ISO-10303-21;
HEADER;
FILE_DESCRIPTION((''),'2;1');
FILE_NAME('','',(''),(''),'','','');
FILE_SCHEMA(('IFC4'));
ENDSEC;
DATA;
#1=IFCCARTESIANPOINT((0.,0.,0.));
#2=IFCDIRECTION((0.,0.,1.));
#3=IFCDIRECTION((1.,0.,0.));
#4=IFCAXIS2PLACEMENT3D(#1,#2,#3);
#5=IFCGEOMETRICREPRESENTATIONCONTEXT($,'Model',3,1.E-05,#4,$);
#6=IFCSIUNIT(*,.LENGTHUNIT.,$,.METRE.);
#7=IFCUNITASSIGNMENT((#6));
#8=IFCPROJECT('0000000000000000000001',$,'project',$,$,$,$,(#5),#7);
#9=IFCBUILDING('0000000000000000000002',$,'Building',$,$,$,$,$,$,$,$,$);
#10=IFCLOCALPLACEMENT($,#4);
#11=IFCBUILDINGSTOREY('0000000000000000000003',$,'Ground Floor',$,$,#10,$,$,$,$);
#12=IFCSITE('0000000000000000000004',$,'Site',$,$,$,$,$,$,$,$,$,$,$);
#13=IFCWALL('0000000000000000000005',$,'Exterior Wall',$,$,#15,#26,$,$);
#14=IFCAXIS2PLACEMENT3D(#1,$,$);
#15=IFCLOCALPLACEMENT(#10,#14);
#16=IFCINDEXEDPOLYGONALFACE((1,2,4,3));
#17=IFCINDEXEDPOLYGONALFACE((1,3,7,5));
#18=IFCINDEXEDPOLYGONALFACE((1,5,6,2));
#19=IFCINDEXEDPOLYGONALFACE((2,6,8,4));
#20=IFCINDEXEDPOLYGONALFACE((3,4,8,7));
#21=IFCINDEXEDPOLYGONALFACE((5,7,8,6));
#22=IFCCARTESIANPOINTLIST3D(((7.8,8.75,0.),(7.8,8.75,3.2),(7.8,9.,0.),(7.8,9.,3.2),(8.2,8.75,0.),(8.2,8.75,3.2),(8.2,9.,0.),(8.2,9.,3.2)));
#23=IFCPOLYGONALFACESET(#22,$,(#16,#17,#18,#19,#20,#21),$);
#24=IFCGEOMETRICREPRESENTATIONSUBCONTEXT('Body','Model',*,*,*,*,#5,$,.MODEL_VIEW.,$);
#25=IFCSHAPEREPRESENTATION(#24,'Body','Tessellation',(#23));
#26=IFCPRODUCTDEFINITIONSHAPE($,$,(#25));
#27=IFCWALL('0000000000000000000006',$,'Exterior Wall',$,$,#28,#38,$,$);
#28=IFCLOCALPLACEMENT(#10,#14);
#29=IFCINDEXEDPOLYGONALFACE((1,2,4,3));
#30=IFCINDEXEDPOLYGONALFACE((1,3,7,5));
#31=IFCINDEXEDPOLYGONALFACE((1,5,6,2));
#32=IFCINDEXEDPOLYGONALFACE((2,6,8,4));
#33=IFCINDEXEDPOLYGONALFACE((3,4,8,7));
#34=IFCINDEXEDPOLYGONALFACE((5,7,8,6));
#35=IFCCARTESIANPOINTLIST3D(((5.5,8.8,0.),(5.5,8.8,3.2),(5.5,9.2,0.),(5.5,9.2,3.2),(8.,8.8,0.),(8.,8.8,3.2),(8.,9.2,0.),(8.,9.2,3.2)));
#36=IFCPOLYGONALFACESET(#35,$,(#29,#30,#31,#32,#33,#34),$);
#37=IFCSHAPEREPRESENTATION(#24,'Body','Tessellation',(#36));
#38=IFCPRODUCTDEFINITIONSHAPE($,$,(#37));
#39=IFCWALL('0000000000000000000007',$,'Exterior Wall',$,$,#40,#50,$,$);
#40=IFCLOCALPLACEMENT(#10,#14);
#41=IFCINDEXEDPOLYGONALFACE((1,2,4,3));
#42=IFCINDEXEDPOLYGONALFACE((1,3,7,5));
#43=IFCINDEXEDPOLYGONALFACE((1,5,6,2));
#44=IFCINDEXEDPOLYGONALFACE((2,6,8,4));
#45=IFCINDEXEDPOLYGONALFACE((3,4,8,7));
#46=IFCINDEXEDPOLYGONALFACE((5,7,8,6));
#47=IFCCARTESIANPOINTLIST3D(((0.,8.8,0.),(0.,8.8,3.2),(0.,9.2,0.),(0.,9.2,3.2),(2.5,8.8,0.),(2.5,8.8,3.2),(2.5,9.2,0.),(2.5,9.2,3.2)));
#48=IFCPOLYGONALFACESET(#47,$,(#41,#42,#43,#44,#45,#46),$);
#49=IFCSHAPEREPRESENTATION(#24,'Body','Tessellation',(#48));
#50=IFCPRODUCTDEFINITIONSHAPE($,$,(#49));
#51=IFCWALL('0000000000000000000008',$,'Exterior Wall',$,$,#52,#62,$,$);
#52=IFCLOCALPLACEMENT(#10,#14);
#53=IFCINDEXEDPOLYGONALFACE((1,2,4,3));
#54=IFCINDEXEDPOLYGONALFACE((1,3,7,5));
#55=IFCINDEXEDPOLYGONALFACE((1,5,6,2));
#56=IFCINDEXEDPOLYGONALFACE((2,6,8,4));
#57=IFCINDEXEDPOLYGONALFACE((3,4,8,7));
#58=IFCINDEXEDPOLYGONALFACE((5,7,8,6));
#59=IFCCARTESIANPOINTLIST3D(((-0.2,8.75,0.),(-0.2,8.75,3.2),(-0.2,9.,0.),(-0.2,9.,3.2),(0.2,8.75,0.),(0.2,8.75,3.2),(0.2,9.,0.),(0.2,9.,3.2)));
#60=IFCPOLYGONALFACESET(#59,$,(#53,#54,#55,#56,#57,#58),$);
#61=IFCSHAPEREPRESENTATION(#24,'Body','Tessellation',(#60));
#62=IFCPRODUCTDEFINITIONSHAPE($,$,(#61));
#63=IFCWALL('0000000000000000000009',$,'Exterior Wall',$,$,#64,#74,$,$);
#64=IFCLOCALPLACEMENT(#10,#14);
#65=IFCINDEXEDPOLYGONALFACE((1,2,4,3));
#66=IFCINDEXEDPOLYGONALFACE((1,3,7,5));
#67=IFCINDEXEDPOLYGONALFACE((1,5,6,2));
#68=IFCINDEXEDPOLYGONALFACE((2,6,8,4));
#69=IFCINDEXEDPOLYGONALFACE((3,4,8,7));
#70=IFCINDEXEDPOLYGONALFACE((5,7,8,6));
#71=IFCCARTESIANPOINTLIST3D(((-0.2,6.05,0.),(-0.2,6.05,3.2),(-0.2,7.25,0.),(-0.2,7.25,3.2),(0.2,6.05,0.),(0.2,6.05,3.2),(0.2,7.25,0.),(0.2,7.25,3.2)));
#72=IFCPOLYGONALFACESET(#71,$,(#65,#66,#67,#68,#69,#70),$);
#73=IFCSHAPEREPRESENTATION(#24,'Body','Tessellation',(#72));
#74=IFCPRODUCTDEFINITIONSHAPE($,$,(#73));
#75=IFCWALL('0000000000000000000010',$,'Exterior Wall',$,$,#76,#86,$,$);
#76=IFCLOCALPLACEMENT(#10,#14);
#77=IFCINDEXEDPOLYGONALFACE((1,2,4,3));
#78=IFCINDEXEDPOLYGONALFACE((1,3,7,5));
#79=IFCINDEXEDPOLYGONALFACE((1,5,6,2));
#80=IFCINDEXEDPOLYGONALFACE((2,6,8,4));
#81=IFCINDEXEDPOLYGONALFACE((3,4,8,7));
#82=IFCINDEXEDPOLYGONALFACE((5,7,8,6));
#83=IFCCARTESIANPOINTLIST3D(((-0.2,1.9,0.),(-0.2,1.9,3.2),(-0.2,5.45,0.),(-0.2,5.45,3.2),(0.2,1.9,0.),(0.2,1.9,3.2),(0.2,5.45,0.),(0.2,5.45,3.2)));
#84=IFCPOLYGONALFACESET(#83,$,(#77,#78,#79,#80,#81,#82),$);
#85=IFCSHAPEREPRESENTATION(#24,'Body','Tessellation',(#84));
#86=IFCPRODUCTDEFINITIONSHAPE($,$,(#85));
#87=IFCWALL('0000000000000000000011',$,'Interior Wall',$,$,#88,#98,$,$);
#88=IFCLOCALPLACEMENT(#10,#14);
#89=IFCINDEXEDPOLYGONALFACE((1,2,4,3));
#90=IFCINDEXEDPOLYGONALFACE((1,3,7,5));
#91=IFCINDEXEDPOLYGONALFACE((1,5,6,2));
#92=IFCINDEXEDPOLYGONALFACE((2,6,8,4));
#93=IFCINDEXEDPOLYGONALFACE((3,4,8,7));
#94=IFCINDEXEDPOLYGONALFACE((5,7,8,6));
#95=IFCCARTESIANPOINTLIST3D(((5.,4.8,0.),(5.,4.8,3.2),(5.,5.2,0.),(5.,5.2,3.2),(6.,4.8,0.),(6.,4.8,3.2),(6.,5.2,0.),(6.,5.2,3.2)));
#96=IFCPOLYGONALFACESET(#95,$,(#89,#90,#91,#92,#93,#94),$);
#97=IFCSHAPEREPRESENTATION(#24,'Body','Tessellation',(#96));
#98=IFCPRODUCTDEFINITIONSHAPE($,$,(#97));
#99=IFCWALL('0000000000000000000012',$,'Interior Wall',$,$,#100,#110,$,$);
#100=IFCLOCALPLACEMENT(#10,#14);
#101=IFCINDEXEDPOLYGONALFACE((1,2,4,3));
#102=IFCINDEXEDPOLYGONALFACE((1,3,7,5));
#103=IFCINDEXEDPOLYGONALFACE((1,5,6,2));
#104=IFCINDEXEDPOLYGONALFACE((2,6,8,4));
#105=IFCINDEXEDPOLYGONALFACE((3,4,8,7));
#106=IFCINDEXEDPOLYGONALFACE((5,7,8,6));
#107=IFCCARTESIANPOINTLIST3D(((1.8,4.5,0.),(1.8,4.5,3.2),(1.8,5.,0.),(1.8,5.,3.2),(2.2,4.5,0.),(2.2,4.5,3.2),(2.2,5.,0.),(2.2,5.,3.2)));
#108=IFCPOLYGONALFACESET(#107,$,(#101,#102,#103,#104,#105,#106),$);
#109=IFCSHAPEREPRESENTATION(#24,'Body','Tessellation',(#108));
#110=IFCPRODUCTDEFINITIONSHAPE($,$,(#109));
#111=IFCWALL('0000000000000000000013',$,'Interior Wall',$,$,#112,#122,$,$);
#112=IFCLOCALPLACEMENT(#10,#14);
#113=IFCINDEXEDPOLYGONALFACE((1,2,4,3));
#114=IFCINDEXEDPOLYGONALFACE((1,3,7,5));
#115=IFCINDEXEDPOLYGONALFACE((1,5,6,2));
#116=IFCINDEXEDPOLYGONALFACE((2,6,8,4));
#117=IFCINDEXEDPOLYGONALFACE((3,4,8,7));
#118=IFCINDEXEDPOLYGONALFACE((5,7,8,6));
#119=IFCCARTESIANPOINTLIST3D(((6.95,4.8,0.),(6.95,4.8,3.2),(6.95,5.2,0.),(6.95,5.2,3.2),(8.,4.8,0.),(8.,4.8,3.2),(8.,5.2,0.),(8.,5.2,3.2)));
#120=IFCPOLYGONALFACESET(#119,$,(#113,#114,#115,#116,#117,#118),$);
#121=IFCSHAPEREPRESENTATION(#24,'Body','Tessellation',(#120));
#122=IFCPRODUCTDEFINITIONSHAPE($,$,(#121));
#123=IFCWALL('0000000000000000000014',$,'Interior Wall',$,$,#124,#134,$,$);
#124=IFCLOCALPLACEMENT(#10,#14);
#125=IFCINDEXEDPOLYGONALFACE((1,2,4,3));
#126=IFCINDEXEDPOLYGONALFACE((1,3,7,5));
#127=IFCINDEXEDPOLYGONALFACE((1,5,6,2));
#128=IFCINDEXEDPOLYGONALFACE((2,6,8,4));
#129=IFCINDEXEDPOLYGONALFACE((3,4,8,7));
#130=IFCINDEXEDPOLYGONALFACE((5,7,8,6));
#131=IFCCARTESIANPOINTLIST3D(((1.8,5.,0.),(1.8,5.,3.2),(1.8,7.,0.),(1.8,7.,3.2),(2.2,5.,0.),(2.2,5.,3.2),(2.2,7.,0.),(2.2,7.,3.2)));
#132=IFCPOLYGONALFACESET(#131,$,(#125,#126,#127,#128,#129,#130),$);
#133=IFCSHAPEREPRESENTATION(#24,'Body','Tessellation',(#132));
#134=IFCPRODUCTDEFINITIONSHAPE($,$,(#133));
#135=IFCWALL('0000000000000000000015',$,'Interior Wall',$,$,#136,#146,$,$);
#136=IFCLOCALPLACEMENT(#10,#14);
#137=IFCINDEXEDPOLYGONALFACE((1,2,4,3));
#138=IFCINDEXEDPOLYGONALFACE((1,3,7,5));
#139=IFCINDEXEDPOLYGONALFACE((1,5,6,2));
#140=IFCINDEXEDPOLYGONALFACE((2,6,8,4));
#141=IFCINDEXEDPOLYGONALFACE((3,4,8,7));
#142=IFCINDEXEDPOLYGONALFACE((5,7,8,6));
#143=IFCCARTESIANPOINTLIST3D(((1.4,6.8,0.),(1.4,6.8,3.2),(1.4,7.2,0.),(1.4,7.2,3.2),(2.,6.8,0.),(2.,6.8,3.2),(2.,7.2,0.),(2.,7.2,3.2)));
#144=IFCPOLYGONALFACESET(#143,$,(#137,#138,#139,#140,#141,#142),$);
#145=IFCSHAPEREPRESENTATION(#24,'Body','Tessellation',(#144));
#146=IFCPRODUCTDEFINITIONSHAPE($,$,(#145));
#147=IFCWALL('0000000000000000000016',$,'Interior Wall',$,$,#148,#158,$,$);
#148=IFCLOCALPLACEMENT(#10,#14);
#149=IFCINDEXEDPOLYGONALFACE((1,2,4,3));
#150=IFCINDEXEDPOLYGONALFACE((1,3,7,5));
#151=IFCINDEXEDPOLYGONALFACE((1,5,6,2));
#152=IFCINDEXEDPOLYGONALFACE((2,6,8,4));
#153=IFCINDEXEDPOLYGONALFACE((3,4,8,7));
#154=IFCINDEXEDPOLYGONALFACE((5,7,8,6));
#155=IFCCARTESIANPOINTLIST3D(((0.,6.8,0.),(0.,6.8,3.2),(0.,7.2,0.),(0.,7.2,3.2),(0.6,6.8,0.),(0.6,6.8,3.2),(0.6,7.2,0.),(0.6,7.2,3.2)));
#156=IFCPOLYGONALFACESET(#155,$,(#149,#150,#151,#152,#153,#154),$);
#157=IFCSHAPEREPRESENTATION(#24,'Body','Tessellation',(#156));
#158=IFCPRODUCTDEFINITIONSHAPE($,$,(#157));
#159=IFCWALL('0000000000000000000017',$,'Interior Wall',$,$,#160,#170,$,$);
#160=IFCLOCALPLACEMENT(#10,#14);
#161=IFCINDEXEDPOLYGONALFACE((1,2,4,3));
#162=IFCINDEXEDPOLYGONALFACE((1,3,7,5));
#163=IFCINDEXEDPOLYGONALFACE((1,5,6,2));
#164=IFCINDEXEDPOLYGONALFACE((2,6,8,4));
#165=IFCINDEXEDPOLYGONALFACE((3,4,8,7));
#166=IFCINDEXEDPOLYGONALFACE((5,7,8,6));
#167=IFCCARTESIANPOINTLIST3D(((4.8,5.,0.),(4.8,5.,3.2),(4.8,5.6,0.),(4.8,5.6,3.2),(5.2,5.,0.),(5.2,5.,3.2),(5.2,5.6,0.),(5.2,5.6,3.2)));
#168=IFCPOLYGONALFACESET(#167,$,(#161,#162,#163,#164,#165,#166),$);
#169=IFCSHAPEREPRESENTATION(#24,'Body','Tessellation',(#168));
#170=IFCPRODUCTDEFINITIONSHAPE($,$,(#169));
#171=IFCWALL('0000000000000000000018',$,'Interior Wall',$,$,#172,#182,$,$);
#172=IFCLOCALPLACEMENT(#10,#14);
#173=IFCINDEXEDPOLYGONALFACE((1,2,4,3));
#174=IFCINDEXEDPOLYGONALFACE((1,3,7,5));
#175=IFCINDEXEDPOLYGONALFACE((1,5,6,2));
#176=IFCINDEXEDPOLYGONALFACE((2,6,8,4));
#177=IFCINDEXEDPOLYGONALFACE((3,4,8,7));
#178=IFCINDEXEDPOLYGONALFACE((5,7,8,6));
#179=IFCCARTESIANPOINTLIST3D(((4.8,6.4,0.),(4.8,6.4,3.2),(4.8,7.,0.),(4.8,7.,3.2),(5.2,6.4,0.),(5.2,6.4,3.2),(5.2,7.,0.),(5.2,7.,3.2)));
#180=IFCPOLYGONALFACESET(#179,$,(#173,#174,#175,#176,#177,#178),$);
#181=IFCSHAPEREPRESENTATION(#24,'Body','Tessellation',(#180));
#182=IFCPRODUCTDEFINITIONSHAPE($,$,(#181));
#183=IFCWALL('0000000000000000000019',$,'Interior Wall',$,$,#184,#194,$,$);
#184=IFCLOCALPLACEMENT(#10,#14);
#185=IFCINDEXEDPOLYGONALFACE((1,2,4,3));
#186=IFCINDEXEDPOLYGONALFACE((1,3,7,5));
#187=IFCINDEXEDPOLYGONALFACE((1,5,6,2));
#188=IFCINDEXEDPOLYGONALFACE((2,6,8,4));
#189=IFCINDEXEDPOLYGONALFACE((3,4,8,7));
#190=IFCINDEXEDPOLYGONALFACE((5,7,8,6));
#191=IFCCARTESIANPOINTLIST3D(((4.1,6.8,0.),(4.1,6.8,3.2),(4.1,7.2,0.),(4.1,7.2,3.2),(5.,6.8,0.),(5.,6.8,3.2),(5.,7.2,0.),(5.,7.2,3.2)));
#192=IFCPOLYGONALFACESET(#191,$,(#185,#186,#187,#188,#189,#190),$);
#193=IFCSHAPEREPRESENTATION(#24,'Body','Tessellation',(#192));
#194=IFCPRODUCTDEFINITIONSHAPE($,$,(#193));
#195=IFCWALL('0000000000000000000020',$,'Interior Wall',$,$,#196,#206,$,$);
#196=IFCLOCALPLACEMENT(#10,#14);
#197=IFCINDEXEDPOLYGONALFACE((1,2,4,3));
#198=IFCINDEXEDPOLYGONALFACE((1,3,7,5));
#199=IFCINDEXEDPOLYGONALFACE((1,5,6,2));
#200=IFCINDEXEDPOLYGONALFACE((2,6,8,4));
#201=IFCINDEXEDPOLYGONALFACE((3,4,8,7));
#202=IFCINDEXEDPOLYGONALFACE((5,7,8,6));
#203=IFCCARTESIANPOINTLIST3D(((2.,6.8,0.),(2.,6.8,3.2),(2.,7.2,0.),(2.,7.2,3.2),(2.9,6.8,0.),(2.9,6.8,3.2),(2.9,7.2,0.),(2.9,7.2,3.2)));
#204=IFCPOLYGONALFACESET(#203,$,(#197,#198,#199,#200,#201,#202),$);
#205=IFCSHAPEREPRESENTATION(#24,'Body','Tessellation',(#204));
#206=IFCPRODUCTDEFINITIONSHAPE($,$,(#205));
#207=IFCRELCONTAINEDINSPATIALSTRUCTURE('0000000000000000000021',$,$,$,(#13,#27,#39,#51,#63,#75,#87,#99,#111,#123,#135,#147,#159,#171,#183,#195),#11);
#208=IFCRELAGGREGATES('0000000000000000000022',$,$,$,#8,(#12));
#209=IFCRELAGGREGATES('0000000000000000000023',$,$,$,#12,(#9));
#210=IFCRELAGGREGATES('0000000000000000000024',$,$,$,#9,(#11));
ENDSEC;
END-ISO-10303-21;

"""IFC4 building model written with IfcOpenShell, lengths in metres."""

from ifc_helpers import new_model, si_unit, frame, origin_with_axes, place, context, subcontext, project, spatial, indexed_curve, outline, extrude, element, save


model = new_model("IFC4")

# Units and contexts
model_context = context("Model", 3, precision=1e-05, world=origin_with_axes())
body_context = subcontext(model_context, "Body", "Model", "MODEL_VIEW")
ifc_project = project(units=[si_unit("LENGTHUNIT", "METRE")], contexts=[model_context])

# Site, building, storey
site = spatial("IfcSite", under=ifc_project, Name="Site")
building = spatial("IfcBuilding", under=site, Name="Building")
storey_placement = place(None, origin_with_axes())
storey = spatial("IfcBuildingStorey", under=building, at=storey_placement, Name="Ground Floor")

# Walls
wall_1_placement = place(storey_placement, frame((8.0, 8.75, 0.0), z_axis=(0.0, 0.0, 1.0), x_axis=(0.0, 1.0, 0.0)))
element("IfcWall", 1, at=wall_1_placement, inside=storey, Name="Exterior Wall", context=body_context, shape_type="SweptSolid", body=[
    extrude(outline(indexed_curve([(0.0, 0.0), (0.0, 0.4), (0.25, 0.4), (0.25, 0.0), (0.0, 0.0)], self_intersect=False)), frame((0.0, -0.2, 0.0), z_axis=(0.0, 0.0, 1.0), x_axis=(1.0, 0.0, 0.0)), (0.0, 0.0, 1.0), 3.2),
])
for number, where, z_axis, x_axis, name in (
    (2, (8.0, 9.0, 0.0), (0.0, 0.0, 1.0), (-1.0, 0.0, 0.0), "Exterior Wall"),
    (3, (2.5, 9.0, 0.0), (0.0, 0.0, 1.0), (-1.0, 0.0, 0.0), "Exterior Wall"),
):
    element("IfcWall", number, at=place(storey_placement, frame(where, z_axis=z_axis, x_axis=x_axis)), inside=storey, Name=name, context=body_context, shape_type="SweptSolid", body=[
        extrude(outline(indexed_curve([(0.0, 0.0), (0.0, 0.4), (2.5, 0.4), (2.5, 0.0), (0.0, 0.0)], self_intersect=False)), frame((0.0, -0.2, 0.0), z_axis=(0.0, 0.0, 1.0), x_axis=(1.0, 0.0, 0.0)), (0.0, 0.0, 1.0), 3.2),
    ])
wall_2_placement = place(storey_placement, frame((0.0, 9.0, 0.0), z_axis=(0.0, 0.0, 1.0), x_axis=(0.0, -1.0, 0.0)))
element("IfcWall", 4, at=wall_2_placement, inside=storey, Name="Exterior Wall", context=body_context, shape_type="SweptSolid", body=[
    extrude(outline(indexed_curve([(0.0, 0.0), (0.0, 0.4), (0.25, 0.4), (0.25, 0.0), (0.0, 0.0)], self_intersect=False)), frame((0.0, -0.2, 0.0), z_axis=(0.0, 0.0, 1.0), x_axis=(1.0, 0.0, 0.0)), (0.0, 0.0, 1.0), 3.2),
])
wall_3_placement = place(storey_placement, frame((0.0, 7.25, 0.0), z_axis=(0.0, 0.0, 1.0), x_axis=(0.0, -1.0, 0.0)))
element("IfcWall", 5, at=wall_3_placement, inside=storey, Name="Exterior Wall", context=body_context, shape_type="SweptSolid", body=[
    extrude(outline(indexed_curve([(0.0, 0.0), (0.0, 0.4), (1.2, 0.4), (1.2, 0.0), (0.0, 0.0)], self_intersect=False)), frame((0.0, -0.2, 0.0), z_axis=(0.0, 0.0, 1.0), x_axis=(1.0, 0.0, 0.0)), (0.0, 0.0, 1.0), 3.2),
])
wall_4_placement = place(storey_placement, frame((0.0, 5.45, 0.0), z_axis=(0.0, 0.0, 1.0), x_axis=(0.0, -1.0, 0.0)))
element("IfcWall", 6, at=wall_4_placement, inside=storey, Name="Exterior Wall", context=body_context, shape_type="SweptSolid", body=[
    extrude(outline(indexed_curve([(0.0, 0.0), (0.0, 0.4), (3.55, 0.4), (3.55, 0.0), (0.0, 0.0)], self_intersect=False)), frame((0.0, -0.2, 0.0), z_axis=(0.0, 0.0, 1.0), x_axis=(1.0, 0.0, 0.0)), (0.0, 0.0, 1.0), 3.2),
])
wall_5_placement = place(storey_placement, frame((6.0, 5.0, 0.0), z_axis=(0.0, 0.0, 1.0), x_axis=(-1.0, 0.0, 0.0)))
element("IfcWall", 7, at=wall_5_placement, inside=storey, Name="Interior Wall", context=body_context, shape_type="SweptSolid", body=[
    extrude(outline(indexed_curve([(0.0, 0.0), (0.0, 0.4), (1.0, 0.4), (1.0, 0.0), (0.0, 0.0)], self_intersect=False)), frame((0.0, -0.2, 0.0), z_axis=(0.0, 0.0, 1.0), x_axis=(1.0, 0.0, 0.0)), (0.0, 0.0, 1.0), 3.2),
])
wall_6_placement = place(storey_placement, frame((2.0, 5.0, 0.0), z_axis=(0.0, 0.0, 1.0), x_axis=(0.0, -1.0, 0.0)))
element("IfcWall", 8, at=wall_6_placement, inside=storey, Name="Interior Wall", context=body_context, shape_type="SweptSolid", body=[
    extrude(outline(indexed_curve([(0.0, 0.0), (0.0, 0.4), (0.5, 0.4), (0.5, 0.0), (0.0, 0.0)], self_intersect=False)), frame((0.0, -0.2, 0.0), z_axis=(0.0, 0.0, 1.0), x_axis=(1.0, 0.0, 0.0)), (0.0, 0.0, 1.0), 3.2),
])
wall_7_placement = place(storey_placement, frame((8.0, 5.0, 0.0), z_axis=(0.0, 0.0, 1.0), x_axis=(-1.0, 0.0, 0.0)))
element("IfcWall", 9, at=wall_7_placement, inside=storey, Name="Interior Wall", context=body_context, shape_type="SweptSolid", body=[
    extrude(outline(indexed_curve([(0.0, 0.0), (0.0, 0.4), (1.05, 0.4), (1.05, 0.0), (0.0, 0.0)], self_intersect=False)), frame((0.0, -0.2, 0.0), z_axis=(0.0, 0.0, 1.0), x_axis=(1.0, 0.0, 0.0)), (0.0, 0.0, 1.0), 3.2),
])
wall_8_placement = place(storey_placement, frame((2.0, 5.0, 0.0), z_axis=(0.0, 0.0, 1.0), x_axis=(0.0, 1.0, 0.0)))
element("IfcWall", 10, at=wall_8_placement, inside=storey, Name="Interior Wall", context=body_context, shape_type="SweptSolid", body=[
    extrude(outline(indexed_curve([(0.0, 0.0), (0.0, 0.4), (2.0, 0.4), (2.0, 0.0), (0.0, 0.0)], self_intersect=False)), frame((0.0, -0.2, 0.0), z_axis=(0.0, 0.0, 1.0), x_axis=(1.0, 0.0, 0.0)), (0.0, 0.0, 1.0), 3.2),
])
for number, where, z_axis, x_axis, name in (
    (11, (2.0, 7.0, 0.0), (0.0, 0.0, 1.0), (-1.0, 0.0, 0.0), "Interior Wall"),
    (12, (0.6, 7.0, 0.0), (0.0, 0.0, 1.0), (-1.0, 0.0, 0.0), "Interior Wall"),
):
    element("IfcWall", number, at=place(storey_placement, frame(where, z_axis=z_axis, x_axis=x_axis)), inside=storey, Name=name, context=body_context, shape_type="SweptSolid", body=[
        extrude(outline(indexed_curve([(0.0, 0.0), (0.0, 0.4), (0.6, 0.4), (0.6, 0.0), (0.0, 0.0)], self_intersect=False)), frame((0.0, -0.2, 0.0), z_axis=(0.0, 0.0, 1.0), x_axis=(1.0, 0.0, 0.0)), (0.0, 0.0, 1.0), 3.2),
    ])
for number, where, z_axis, x_axis, name in (
    (13, (5.0, 5.0, 0.0), (0.0, 0.0, 1.0), (0.0, 1.0, 0.0), "Interior Wall"),
    (14, (5.0, 6.4, 0.0), (0.0, 0.0, 1.0), (0.0, 1.0, 0.0), "Interior Wall"),
):
    element("IfcWall", number, at=place(storey_placement, frame(where, z_axis=z_axis, x_axis=x_axis)), inside=storey, Name=name, context=body_context, shape_type="SweptSolid", body=[
        extrude(outline(indexed_curve([(0.0, 0.0), (0.0, 0.4), (0.6, 0.4), (0.6, 0.0), (0.0, 0.0)], self_intersect=False)), frame((0.0, -0.2, 0.0), z_axis=(0.0, 0.0, 1.0), x_axis=(1.0, 0.0, 0.0)), (0.0, 0.0, 1.0), 3.2),
    ])
wall_9_placement = place(storey_placement, frame((5.0, 7.0, 0.0), z_axis=(0.0, 0.0, 1.0), x_axis=(-1.0, 0.0, 0.0)))
element("IfcWall", 15, at=wall_9_placement, inside=storey, Name="Interior Wall", context=body_context, shape_type="SweptSolid", body=[
    extrude(outline(indexed_curve([(0.0, 0.0), (0.0, 0.4), (0.9, 0.4), (0.9, 0.0), (0.0, 0.0)], self_intersect=False)), frame((0.0, -0.2, 0.0), z_axis=(0.0, 0.0, 1.0), x_axis=(1.0, 0.0, 0.0)), (0.0, 0.0, 1.0), 3.2),
])
wall_10_placement = place(storey_placement, frame((2.9, 7.0, 0.0), z_axis=(0.0, 0.0, 1.0), x_axis=(-1.0, 0.0, 0.0)))
element("IfcWall", 16, at=wall_10_placement, inside=storey, Name="Interior Wall", context=body_context, shape_type="SweptSolid", body=[
    extrude(outline(indexed_curve([(0.0, 0.0), (0.0, 0.4), (0.9, 0.4), (0.9, 0.0), (0.0, 0.0)], self_intersect=False)), frame((0.0, -0.2, 0.0), z_axis=(0.0, 0.0, 1.0), x_axis=(1.0, 0.0, 0.0)), (0.0, 0.0, 1.0), 3.2),
])

save(model, "model.ifc")
